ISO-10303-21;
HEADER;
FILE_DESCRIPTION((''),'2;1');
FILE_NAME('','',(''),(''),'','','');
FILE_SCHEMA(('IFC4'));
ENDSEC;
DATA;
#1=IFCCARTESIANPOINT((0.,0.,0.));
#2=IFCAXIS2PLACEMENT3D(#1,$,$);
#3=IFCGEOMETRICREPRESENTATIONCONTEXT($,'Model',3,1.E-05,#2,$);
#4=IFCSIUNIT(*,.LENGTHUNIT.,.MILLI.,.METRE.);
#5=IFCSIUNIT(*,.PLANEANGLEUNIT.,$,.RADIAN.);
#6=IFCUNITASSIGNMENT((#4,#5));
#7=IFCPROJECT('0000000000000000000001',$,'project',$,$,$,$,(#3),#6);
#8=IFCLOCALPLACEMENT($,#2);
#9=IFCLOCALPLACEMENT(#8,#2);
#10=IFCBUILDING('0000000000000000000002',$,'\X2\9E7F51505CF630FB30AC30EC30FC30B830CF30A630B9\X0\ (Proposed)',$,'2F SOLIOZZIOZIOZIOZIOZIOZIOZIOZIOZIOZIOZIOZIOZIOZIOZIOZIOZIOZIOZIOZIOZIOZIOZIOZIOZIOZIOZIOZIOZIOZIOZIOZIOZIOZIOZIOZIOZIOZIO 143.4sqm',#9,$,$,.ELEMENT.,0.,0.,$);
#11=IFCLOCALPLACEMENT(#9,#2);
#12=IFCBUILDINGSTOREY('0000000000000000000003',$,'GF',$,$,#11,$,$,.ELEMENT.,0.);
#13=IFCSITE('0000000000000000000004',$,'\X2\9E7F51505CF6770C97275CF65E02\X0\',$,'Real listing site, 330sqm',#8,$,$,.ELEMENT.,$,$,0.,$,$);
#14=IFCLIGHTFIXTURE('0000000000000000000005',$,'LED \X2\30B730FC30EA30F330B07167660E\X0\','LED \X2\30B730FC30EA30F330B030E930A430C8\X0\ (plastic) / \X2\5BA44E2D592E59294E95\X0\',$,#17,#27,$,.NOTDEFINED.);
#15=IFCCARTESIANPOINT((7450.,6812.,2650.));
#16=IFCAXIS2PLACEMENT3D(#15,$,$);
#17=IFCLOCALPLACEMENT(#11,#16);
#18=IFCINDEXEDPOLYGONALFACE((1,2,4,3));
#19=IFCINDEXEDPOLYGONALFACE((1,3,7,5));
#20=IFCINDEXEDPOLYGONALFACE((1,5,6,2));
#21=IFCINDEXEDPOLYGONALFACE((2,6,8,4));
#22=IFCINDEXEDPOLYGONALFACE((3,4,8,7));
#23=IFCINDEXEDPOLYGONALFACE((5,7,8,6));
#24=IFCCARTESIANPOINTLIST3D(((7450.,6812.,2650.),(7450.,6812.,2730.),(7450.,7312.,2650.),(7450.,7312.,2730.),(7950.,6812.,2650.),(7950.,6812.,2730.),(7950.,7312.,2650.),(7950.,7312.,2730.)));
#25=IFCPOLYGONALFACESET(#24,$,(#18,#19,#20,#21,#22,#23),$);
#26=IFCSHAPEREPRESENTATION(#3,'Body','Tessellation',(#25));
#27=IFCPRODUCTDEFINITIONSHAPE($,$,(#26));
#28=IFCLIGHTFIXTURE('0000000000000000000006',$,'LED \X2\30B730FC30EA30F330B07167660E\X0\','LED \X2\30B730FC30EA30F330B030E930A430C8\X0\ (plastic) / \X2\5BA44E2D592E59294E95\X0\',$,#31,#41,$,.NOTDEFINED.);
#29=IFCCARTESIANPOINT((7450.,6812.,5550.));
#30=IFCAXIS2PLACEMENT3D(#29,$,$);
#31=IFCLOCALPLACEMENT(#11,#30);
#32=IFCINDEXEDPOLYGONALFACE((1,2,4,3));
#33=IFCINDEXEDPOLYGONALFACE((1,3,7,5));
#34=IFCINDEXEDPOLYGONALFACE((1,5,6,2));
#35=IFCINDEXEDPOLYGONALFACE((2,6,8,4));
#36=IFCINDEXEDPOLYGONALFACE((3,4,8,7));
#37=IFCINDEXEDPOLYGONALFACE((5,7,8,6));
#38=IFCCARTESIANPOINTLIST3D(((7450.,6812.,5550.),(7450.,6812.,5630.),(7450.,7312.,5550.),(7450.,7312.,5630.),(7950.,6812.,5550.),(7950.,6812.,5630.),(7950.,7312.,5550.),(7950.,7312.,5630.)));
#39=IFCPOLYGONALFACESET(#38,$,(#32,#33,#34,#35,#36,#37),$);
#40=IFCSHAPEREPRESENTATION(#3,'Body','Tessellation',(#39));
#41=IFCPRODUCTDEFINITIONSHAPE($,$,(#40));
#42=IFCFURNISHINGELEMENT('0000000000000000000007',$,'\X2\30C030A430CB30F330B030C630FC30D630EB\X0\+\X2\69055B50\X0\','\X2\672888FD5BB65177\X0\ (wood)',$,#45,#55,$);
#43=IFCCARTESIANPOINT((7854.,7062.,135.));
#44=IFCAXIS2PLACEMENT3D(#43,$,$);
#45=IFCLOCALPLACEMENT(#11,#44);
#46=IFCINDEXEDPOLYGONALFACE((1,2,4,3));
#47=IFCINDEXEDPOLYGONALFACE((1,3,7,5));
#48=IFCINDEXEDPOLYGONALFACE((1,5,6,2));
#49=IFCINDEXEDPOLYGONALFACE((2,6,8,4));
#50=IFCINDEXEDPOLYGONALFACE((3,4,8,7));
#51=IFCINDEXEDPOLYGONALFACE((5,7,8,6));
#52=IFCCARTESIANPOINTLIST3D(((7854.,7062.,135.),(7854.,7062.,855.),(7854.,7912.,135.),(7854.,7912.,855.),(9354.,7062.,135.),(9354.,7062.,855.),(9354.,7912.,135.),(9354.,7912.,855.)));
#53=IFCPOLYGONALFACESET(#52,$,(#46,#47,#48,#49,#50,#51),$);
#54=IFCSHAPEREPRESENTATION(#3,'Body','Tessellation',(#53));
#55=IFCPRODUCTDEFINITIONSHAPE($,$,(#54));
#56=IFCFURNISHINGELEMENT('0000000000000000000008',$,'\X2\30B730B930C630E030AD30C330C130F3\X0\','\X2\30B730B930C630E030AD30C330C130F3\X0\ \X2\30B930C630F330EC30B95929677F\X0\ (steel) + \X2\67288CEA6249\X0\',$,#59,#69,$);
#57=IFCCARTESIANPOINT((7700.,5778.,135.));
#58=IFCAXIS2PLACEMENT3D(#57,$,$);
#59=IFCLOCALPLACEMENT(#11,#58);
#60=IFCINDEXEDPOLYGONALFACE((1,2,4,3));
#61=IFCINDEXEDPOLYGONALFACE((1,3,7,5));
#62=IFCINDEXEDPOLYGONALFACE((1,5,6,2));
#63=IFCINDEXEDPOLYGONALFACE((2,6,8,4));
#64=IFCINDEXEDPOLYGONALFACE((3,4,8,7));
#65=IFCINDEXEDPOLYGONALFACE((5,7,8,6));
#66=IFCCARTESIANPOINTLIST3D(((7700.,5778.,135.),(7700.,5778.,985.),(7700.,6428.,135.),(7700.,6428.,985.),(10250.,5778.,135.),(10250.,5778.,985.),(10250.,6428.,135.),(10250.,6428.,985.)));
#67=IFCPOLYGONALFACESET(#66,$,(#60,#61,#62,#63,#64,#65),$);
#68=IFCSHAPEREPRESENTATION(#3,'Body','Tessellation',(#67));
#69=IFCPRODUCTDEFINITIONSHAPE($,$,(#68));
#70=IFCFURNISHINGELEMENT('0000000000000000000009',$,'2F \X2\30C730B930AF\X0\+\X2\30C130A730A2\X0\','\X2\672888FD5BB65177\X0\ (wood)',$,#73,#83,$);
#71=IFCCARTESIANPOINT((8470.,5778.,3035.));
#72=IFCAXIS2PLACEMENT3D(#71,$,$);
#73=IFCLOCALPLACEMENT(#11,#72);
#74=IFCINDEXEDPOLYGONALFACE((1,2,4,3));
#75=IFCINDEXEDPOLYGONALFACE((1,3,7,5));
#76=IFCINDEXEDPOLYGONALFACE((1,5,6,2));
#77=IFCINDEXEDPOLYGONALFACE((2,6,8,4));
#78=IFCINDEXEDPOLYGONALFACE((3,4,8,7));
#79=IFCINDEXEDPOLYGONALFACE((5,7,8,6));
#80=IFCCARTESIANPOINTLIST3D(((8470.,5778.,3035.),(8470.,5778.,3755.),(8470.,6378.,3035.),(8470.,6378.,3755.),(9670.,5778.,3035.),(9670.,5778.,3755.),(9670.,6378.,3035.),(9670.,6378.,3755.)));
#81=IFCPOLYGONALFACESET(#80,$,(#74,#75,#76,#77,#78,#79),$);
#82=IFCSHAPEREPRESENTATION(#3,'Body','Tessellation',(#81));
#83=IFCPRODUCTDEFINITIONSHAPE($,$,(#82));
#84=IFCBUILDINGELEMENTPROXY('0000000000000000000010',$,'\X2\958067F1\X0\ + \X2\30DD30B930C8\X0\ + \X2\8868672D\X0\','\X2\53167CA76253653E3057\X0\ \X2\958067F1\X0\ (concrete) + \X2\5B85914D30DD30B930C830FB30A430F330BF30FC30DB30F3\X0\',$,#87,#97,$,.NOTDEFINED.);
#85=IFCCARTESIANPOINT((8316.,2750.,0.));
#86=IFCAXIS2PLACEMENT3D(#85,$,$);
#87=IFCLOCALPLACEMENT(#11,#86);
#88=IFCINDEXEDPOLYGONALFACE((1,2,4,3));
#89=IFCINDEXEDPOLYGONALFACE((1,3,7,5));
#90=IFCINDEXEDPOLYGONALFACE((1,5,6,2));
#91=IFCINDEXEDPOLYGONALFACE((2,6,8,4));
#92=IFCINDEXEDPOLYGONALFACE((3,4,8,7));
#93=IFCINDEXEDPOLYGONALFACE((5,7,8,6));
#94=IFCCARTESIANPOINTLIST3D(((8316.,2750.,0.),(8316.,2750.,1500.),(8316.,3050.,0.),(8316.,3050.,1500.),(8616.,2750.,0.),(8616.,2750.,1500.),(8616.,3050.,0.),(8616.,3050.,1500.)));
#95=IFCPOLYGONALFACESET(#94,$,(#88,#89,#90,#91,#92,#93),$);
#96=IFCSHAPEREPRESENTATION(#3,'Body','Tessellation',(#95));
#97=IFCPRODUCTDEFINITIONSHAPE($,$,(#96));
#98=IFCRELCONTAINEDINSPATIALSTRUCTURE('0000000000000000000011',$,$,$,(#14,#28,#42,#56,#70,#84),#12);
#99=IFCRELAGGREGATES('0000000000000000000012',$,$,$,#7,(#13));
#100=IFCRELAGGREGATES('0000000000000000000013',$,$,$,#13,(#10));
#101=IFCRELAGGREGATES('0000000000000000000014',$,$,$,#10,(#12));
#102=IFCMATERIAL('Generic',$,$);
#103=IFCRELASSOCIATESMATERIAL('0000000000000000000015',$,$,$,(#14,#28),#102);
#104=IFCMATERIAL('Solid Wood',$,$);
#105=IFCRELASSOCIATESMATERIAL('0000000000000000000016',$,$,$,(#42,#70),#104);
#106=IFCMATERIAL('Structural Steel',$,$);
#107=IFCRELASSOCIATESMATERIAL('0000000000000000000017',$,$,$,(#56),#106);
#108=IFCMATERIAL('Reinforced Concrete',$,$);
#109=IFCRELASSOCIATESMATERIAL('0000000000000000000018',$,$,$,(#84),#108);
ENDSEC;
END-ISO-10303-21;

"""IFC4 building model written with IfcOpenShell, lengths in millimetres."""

from ifc_helpers import new_model, si_unit, frame, frame_2d, origin, place, context, project, spatial, rectangle, extrude, material, element, save


model = new_model("IFC4")

# Units and contexts
model_context = context("Model", 3, precision=1e-05, world=origin())
ifc_project = project(units=[si_unit("LENGTHUNIT", "METRE", prefix="MILLI"), si_unit("PLANEANGLEUNIT", "RADIAN")], contexts=[model_context])

# Site, building, storey
site_placement = place(None, origin())
site = spatial("IfcSite", under=ifc_project, at=site_placement, Name="鹿児島県霧島市", ObjectType="Real listing site, 330sqm", CompositionType="ELEMENT", RefElevation=0.0)
building_placement = place(site_placement, origin())
building = spatial("IfcBuilding", under=site, at=building_placement, Name="鹿児島・ガレージハウス (Proposed)", ObjectType="2F SOLIOZZIOZIOZIOZIOZIOZIOZIOZIOZIOZIOZIOZIOZIOZIOZIOZIOZIOZIOZIOZIOZIOZIOZIOZIOZIOZIOZIOZIOZIOZIOZIOZIOZIOZIOZIOZIOZIOZIO 143.4sqm", CompositionType="ELEMENT", ElevationOfRefHeight=0.0, ElevationOfTerrain=0.0)
storey_placement = place(building_placement, origin())
storey = spatial("IfcBuildingStorey", under=building, at=storey_placement, Name="GF", CompositionType="ELEMENT", Elevation=0.0)

# Shared definitions
ifc_material_1 = material(Name="Solid Wood")

# Shared definitions
ifc_material_2 = material(Name="Structural Steel")

# Shared definitions
ifc_material_3 = material(Name="Reinforced Concrete")

# Shared definitions
ifc_material_4 = material(Name="Generic")

# Light fixtures
light_fixture_1_placement = place(storey_placement, frame((7450.0, 6812.0, 2650.0)))
element("IfcLightFixture", 1, at=light_fixture_1_placement, inside=storey, material=ifc_material_4, Name="LED シーリング照明", Description="LED シーリングライト (plastic) / 室中央天井", PredefinedType="NOTDEFINED", context=model_context, shape_type="SweptSolid", body=[
    extrude(rectangle(XDim=500.0, YDim=500.0, at=frame_2d((250.0, 250.0))), frame((7450.0, 6812.0, 2650.0)), (0.0, 0.0, 1.0), 80.0),
])
light_fixture_2_placement = place(storey_placement, frame((7450.0, 6812.0, 5550.0)))
element("IfcLightFixture", 2, at=light_fixture_2_placement, inside=storey, material=ifc_material_4, Name="LED シーリング照明", Description="LED シーリングライト (plastic) / 室中央天井", PredefinedType="NOTDEFINED", context=model_context, shape_type="SweptSolid", body=[
    extrude(rectangle(XDim=500.0, YDim=500.0, at=frame_2d((250.0, 250.0))), frame((7450.0, 6812.0, 5550.0)), (0.0, 0.0, 1.0), 80.0),
])

# Furnishing elements
furnishing_1_placement = place(storey_placement, frame((7854.0, 7062.0, 135.0)))
element("IfcFurnishingElement", 3, at=furnishing_1_placement, inside=storey, material=ifc_material_1, Name="ダイニングテーブル+椅子", Description="木製家具 (wood)", context=model_context, shape_type="SweptSolid", body=[
    extrude(rectangle(XDim=1500.0, YDim=850.0, at=frame_2d((750.0, 425.0))), frame((7854.0, 7062.0, 135.0)), (0.0, 0.0, 1.0), 720.0),
])
furnishing_2_placement = place(storey_placement, frame((7700.0, 5778.0, 135.0)))
element("IfcFurnishingElement", 4, at=furnishing_2_placement, inside=storey, material=ifc_material_2, Name="システムキッチン", Description="システムキッチン ステンレス天板 (steel) + 木質扉", context=model_context, shape_type="SweptSolid", body=[
    extrude(rectangle(XDim=2550.0, YDim=650.0, at=frame_2d((1275.0, 325.0))), frame((7700.0, 5778.0, 135.0)), (0.0, 0.0, 1.0), 850.0),
])
furnishing_3_placement = place(storey_placement, frame((8470.0, 5778.0, 3035.0)))
element("IfcFurnishingElement", 5, at=furnishing_3_placement, inside=storey, material=ifc_material_1, Name="2F デスク+チェア", Description="木製家具 (wood)", context=model_context, shape_type="SweptSolid", body=[
    extrude(rectangle(XDim=1200.0, YDim=600.0, at=frame_2d((600.0, 300.0))), frame((8470.0, 5778.0, 3035.0)), (0.0, 0.0, 1.0), 720.0),
])

# Building element proxy
proxy_placement = place(storey_placement, frame((8316.0, 2750.0, 0.0)))
element("IfcBuildingElementProxy", 6, at=proxy_placement, inside=storey, material=ifc_material_3, Name="門柱 + ポスト + 表札", Description="化粧打放し 門柱 (concrete) + 宅配ポスト・インターホン", PredefinedType="NOTDEFINED", context=model_context, shape_type="SweptSolid", body=[
    extrude(rectangle(XDim=300.0, YDim=300.0, at=frame_2d((150.0, 150.0))), frame((8316.0, 2750.0, 0.0)), (0.0, 0.0, 1.0), 1500.0),
])

save(model, "model.ifc")
